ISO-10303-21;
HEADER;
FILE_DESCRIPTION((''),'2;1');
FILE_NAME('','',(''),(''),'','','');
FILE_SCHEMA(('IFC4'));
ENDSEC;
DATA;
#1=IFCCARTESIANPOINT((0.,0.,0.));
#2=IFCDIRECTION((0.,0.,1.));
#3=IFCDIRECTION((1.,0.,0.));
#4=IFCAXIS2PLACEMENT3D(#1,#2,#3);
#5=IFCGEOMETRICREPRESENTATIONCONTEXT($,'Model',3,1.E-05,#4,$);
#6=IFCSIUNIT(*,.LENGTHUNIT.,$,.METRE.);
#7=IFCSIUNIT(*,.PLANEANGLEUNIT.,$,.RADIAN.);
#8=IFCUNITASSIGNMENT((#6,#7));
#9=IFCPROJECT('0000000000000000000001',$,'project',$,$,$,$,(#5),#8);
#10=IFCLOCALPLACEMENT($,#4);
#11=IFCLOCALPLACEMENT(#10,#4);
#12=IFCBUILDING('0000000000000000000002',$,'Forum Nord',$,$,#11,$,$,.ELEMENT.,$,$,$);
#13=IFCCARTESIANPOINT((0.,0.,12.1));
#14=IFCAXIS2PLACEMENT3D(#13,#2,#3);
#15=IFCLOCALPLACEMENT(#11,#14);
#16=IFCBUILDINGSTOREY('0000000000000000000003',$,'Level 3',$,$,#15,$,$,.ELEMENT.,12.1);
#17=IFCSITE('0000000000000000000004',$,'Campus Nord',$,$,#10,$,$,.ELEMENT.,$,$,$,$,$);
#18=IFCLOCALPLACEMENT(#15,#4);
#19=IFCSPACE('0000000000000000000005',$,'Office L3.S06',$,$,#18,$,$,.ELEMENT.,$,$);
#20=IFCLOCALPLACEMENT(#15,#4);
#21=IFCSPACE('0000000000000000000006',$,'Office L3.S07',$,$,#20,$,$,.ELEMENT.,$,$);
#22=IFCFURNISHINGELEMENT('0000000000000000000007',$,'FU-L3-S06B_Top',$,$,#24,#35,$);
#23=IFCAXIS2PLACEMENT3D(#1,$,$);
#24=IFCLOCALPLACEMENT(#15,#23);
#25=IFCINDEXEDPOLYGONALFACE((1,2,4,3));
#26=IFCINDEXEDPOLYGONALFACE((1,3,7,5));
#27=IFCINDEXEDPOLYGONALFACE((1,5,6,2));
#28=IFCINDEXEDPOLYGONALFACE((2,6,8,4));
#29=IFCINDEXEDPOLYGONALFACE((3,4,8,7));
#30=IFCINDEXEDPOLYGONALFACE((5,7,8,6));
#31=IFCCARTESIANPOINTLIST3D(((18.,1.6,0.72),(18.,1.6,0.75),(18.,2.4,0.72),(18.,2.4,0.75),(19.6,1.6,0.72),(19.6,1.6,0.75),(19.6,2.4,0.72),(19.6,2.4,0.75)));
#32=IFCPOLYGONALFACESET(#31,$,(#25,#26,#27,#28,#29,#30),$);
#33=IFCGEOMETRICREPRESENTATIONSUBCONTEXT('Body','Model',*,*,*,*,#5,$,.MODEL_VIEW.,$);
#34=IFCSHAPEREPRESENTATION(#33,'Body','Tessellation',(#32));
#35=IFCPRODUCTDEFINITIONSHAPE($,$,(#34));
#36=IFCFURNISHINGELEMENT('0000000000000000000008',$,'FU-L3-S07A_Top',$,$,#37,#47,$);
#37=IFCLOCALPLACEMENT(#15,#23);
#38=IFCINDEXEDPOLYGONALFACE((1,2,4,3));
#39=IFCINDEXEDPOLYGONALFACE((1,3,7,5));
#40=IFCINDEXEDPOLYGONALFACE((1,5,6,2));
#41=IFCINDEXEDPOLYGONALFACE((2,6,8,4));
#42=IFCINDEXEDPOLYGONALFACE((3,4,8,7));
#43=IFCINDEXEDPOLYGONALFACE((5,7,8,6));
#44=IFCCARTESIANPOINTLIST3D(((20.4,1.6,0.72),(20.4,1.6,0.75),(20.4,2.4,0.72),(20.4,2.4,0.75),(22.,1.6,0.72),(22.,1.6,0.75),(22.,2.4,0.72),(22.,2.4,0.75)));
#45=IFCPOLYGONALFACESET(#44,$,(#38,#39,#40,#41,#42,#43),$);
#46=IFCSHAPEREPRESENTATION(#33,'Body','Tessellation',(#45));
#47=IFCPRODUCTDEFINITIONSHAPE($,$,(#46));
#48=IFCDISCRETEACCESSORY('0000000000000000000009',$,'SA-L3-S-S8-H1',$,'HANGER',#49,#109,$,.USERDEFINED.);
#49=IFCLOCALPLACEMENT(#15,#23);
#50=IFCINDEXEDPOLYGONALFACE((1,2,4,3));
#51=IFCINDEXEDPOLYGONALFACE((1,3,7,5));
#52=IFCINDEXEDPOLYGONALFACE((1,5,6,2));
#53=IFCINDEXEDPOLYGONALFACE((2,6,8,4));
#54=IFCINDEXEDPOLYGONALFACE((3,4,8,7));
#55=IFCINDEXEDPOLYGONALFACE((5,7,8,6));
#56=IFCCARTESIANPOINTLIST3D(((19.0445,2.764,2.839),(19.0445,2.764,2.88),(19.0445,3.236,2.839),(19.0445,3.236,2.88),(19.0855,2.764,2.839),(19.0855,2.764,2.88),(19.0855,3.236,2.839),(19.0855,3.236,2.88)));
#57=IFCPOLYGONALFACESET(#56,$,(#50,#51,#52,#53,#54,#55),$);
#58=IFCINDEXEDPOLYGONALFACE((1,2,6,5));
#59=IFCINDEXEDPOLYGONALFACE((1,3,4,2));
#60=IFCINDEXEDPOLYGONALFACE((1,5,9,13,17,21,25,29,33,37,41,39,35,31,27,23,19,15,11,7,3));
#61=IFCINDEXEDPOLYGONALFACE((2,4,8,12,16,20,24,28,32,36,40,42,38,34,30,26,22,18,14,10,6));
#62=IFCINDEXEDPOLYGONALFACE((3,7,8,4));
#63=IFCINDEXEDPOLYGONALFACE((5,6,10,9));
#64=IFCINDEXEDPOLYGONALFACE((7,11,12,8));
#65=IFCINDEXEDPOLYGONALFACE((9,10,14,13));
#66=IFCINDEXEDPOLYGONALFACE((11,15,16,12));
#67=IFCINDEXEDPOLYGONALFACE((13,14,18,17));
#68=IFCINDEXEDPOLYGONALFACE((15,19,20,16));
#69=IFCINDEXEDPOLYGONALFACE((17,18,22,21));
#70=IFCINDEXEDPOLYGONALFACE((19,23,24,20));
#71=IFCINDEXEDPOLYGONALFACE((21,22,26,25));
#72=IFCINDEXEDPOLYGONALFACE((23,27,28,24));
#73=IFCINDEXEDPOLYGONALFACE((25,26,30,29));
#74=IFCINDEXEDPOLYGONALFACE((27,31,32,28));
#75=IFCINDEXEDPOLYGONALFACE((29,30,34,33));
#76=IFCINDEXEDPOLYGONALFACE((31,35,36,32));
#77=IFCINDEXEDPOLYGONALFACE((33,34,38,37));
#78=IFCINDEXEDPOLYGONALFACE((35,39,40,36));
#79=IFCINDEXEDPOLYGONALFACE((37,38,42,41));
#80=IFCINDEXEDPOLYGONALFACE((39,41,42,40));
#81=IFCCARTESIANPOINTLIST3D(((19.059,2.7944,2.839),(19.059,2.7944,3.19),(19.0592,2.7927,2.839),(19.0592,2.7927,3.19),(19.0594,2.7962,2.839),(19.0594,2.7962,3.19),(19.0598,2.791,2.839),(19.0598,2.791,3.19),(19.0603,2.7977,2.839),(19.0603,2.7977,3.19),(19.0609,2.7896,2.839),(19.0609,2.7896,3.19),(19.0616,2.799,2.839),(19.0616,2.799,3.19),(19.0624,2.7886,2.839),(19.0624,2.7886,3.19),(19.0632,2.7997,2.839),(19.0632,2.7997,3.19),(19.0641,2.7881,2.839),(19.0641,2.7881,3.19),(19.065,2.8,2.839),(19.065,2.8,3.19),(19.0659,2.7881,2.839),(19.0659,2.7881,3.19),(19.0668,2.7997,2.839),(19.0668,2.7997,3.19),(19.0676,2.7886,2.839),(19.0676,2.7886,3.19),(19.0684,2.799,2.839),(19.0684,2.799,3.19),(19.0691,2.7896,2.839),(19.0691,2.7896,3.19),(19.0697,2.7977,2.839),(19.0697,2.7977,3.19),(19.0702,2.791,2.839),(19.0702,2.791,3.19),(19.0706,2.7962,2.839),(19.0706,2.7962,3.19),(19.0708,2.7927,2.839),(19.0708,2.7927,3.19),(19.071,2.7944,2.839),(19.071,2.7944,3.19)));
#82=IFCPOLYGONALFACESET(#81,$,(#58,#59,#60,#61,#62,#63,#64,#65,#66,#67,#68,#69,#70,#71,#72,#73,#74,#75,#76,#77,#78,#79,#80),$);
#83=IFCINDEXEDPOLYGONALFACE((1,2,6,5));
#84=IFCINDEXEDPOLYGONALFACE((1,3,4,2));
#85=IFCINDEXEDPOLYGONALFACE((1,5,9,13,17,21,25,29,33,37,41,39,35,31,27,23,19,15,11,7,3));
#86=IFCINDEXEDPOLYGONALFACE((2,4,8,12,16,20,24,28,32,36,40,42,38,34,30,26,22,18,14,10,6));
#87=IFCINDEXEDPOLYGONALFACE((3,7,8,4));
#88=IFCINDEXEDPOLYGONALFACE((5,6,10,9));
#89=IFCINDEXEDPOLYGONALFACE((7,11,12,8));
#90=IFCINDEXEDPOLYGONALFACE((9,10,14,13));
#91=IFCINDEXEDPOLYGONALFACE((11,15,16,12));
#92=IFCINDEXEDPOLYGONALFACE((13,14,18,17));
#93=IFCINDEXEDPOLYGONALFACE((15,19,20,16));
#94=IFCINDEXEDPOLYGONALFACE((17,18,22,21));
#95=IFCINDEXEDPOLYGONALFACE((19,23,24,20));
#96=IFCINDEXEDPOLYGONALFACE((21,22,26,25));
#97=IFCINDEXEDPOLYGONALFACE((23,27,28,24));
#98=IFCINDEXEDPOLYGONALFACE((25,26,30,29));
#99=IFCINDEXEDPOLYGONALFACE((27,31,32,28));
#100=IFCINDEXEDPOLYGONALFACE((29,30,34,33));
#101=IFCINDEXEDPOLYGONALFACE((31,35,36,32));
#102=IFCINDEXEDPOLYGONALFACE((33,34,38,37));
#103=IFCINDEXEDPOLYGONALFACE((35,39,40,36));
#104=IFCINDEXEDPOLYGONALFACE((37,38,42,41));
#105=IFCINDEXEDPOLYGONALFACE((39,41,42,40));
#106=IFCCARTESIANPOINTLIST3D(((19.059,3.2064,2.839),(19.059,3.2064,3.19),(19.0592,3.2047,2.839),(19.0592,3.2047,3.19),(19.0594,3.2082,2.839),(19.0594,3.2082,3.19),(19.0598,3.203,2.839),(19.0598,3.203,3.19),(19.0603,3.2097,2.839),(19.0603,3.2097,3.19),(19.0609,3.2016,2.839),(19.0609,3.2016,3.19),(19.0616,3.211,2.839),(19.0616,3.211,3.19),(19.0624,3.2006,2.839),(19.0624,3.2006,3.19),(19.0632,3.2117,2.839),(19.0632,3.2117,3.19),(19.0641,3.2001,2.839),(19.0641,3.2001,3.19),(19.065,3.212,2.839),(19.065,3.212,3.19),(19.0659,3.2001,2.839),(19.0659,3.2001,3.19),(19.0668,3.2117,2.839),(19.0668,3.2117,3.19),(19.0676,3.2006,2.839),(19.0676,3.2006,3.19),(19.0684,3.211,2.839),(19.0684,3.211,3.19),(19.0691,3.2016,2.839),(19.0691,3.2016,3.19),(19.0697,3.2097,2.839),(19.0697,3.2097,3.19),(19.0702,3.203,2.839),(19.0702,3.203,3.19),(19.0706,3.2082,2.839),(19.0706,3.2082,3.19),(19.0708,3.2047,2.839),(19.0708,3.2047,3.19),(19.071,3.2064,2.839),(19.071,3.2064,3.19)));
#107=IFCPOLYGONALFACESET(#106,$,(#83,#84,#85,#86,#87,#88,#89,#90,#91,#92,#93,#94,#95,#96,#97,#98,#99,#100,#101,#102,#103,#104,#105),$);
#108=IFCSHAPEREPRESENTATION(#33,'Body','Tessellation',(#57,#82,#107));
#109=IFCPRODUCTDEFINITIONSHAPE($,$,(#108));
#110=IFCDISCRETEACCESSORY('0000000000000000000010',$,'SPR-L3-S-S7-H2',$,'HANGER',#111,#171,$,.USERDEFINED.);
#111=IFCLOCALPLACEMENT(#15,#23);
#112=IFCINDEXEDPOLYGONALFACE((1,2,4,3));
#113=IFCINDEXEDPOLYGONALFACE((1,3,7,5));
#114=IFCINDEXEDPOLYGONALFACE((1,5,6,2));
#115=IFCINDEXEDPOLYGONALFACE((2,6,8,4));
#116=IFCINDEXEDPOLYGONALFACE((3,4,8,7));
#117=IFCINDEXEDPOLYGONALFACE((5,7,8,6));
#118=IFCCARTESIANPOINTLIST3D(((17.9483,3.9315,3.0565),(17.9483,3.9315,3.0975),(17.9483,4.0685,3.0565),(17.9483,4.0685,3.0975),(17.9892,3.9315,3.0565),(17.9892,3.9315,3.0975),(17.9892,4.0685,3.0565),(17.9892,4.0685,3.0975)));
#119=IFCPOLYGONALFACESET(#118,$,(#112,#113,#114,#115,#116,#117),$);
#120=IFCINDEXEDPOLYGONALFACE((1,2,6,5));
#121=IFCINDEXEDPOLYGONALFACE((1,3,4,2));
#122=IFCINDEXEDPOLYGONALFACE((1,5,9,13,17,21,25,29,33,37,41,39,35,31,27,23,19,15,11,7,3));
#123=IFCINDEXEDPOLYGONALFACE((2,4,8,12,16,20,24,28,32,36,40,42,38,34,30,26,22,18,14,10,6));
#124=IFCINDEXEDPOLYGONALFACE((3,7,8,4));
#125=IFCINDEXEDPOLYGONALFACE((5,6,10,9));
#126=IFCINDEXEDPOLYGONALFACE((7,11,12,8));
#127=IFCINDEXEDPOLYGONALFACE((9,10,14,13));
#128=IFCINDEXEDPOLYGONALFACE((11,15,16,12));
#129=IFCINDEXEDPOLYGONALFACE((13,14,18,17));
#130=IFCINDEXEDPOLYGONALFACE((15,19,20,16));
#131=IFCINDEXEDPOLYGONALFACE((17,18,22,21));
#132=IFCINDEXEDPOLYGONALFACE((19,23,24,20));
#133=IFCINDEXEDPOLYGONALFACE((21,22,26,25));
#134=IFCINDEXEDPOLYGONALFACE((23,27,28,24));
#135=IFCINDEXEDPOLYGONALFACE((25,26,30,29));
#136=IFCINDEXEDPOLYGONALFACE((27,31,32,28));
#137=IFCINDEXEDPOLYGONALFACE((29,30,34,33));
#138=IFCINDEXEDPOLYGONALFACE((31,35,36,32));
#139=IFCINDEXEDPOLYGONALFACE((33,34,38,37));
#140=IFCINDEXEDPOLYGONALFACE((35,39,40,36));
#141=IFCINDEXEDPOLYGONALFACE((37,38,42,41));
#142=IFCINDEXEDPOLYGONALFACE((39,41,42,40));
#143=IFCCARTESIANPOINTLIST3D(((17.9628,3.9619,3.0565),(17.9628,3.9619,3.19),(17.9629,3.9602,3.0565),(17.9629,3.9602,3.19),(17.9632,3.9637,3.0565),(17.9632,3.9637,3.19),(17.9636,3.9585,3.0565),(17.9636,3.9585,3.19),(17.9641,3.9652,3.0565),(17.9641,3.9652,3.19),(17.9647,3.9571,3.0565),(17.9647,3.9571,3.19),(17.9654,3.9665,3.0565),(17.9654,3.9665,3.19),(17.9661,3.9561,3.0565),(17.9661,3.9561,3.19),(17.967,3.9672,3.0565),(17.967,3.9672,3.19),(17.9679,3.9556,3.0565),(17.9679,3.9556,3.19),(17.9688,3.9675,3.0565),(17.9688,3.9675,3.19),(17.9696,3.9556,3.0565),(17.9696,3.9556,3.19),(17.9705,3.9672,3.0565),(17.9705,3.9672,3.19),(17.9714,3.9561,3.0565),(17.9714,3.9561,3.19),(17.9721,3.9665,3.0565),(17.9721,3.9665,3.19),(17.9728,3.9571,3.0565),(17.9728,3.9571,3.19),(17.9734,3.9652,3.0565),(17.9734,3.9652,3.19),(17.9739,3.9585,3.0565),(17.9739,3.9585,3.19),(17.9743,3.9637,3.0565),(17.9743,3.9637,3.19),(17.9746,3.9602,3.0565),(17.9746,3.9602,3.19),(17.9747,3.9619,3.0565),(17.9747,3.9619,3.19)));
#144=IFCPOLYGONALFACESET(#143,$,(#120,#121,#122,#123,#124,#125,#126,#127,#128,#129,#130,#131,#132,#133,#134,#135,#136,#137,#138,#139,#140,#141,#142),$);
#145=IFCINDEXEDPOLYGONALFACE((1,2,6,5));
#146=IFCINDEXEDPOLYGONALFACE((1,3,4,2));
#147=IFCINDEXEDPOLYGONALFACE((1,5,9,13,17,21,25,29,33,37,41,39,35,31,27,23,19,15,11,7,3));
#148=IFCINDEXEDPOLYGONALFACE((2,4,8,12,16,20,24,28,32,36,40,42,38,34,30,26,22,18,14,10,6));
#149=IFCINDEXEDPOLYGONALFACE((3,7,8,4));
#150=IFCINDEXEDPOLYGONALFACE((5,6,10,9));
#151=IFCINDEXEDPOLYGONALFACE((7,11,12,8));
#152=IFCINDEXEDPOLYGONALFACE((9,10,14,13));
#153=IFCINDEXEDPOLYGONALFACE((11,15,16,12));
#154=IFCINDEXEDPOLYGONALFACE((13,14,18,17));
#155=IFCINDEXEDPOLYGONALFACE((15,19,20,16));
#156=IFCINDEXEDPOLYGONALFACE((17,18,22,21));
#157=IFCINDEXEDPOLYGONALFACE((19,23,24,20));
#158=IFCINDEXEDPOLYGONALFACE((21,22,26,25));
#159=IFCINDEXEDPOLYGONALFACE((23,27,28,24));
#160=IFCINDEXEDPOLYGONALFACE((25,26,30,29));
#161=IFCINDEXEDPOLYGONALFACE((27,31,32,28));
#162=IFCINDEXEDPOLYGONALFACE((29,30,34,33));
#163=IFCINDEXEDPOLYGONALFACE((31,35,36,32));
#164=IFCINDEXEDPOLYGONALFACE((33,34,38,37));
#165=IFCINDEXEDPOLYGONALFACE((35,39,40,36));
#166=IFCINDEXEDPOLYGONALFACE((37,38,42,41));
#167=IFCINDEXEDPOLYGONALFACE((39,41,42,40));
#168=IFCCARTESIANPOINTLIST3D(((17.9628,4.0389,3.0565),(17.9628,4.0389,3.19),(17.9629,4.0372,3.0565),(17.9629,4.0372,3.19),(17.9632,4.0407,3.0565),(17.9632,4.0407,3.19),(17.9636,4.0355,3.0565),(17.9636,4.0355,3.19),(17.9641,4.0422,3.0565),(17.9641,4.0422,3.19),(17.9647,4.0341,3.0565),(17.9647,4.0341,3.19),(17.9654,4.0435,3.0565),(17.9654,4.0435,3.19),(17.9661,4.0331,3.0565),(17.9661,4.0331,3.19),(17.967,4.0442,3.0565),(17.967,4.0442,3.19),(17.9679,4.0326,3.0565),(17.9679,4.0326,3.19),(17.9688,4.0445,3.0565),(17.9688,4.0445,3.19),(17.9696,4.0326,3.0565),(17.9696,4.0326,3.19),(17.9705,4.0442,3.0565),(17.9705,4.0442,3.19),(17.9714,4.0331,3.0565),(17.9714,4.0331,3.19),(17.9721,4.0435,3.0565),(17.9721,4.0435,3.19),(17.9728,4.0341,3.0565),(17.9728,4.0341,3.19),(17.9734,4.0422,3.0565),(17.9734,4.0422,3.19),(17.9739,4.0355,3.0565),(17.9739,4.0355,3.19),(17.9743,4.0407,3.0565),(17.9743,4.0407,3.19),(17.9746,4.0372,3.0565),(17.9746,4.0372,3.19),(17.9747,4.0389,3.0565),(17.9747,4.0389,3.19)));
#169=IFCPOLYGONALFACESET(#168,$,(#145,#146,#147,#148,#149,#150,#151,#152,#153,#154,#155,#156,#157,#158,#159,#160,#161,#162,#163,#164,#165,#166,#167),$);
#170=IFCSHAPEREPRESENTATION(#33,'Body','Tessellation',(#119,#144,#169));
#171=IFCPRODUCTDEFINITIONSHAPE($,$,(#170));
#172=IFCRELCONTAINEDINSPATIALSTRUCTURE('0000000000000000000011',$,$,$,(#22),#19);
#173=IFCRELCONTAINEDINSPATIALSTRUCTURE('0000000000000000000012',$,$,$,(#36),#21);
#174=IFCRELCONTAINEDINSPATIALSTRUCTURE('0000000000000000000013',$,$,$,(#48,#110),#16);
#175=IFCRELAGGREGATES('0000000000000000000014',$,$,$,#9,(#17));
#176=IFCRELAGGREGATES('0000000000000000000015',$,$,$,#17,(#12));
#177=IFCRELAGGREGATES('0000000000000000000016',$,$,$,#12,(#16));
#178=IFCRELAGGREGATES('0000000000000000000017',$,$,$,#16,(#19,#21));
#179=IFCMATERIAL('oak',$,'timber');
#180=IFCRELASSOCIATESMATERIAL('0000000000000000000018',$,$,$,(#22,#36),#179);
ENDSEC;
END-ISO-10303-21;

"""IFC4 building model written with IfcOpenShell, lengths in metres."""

from ifc_helpers import new_model, si_unit, frame, frame_2d, origin_with_axes, origin_2d_with_axis, place, context, subcontext, project, spatial, rectangle, circle, extrude, material, element, save


model = new_model("IFC4")

# Units and contexts
model_context = context("Model", 3, precision=1e-05, world=origin_with_axes())
body_context = subcontext(model_context, "Body", "Model", "MODEL_VIEW")
ifc_project = project(units=[si_unit("LENGTHUNIT", "METRE"), si_unit("PLANEANGLEUNIT", "RADIAN")], contexts=[model_context])

# Site, building, storey
site_placement = place(None, origin_with_axes())
site = spatial("IfcSite", under=ifc_project, at=site_placement, Name="Campus Nord", CompositionType="ELEMENT")
building_placement = place(site_placement, origin_with_axes())
building = spatial("IfcBuilding", under=site, at=building_placement, Name="Forum Nord", CompositionType="ELEMENT")
storey_placement = place(building_placement, frame((0.0, 0.0, 12.1), z_axis=(0.0, 0.0, 1.0), x_axis=(1.0, 0.0, 0.0)))
storey = spatial("IfcBuildingStorey", under=building, at=storey_placement, Name="Level 3", CompositionType="ELEMENT", Elevation=12.1)

# Shared definitions
space_1_placement = place(storey_placement, origin_with_axes())
space_1 = spatial("IfcSpace", under=storey, at=space_1_placement, Name="Office L3.S06", CompositionType="ELEMENT")

# Furnishing element
ifc_material_1 = material(Name="oak", Category="timber")
furnishing_1_placement = place(storey_placement, frame((18.0, 1.0, 0.0), z_axis=(0.0, 0.0, 1.0), x_axis=(1.0, 0.0, 0.0)))
element("IfcFurnishingElement", 1, at=furnishing_1_placement, inside=space_1, material=ifc_material_1, Name="FU-L3-S06B_Top", context=body_context, shape_type="SweptSolid", body=[
    extrude(rectangle(XDim=1.6, YDim=0.8, at=frame_2d((0.8, 1.0), x_axis=(1.0, 0.0))), frame((0.0, 0.0, 0.72), z_axis=(0.0, 0.0, 1.0), x_axis=(1.0, 0.0, 0.0)), (0.0, 0.0, 1.0), 0.03),
])

# Shared definitions
space_2_placement = place(storey_placement, origin_with_axes())
space_2 = spatial("IfcSpace", under=storey, at=space_2_placement, Name="Office L3.S07", CompositionType="ELEMENT")

# Furnishing element
furnishing_2_placement = place(storey_placement, frame((20.4, 1.0, 0.0), z_axis=(0.0, 0.0, 1.0), x_axis=(1.0, 0.0, 0.0)))
element("IfcFurnishingElement", 2, at=furnishing_2_placement, inside=space_2, material=ifc_material_1, Name="FU-L3-S07A_Top", context=body_context, shape_type="SweptSolid", body=[
    extrude(rectangle(XDim=1.6, YDim=0.8, at=frame_2d((0.8, 1.0), x_axis=(1.0, 0.0))), frame((0.0, 0.0, 0.72), z_axis=(0.0, 0.0, 1.0), x_axis=(1.0, 0.0, 0.0)), (0.0, 0.0, 1.0), 0.03),
])

# Discrete accessories
discrete_accessory_1_placement = place(storey_placement, frame((19.065, 3.0, 2.88), z_axis=(0.0, 0.0, 1.0), x_axis=(0.0, 1.0, 0.0)))
element("IfcDiscreteAccessory", 3, at=discrete_accessory_1_placement, inside=storey, Name="SA-L3-S-S8-H1", ObjectType="HANGER", PredefinedType="USERDEFINED", context=body_context, shape_type="SweptSolid", body=[
    extrude(rectangle(XDim=0.472, YDim=0.041, at=origin_2d_with_axis()), frame((0.0, 0.0, -0.041), z_axis=(0.0, 0.0, 1.0), x_axis=(1.0, 0.0, 0.0)), (0.0, 0.0, 1.0), 0.041),
    extrude(circle(Radius=0.006, at=frame_2d((-0.206, 0.0), x_axis=(1.0, 0.0))), frame((0.0, 0.0, -0.041), z_axis=(0.0, 0.0, 1.0), x_axis=(1.0, 0.0, 0.0)), (0.0, 0.0, 1.0), 0.351),
    extrude(circle(Radius=0.006, at=frame_2d((0.206, 0.0), x_axis=(1.0, 0.0))), frame((0.0, 0.0, -0.041), z_axis=(0.0, 0.0, 1.0), x_axis=(1.0, 0.0, 0.0)), (0.0, 0.0, 1.0), 0.351),
])
discrete_accessory_2_placement = place(storey_placement, frame((17.9688, 4.0, 3.0975), z_axis=(0.0, 0.0, 1.0), x_axis=(0.0, 1.0, 0.0)))
element("IfcDiscreteAccessory", 4, at=discrete_accessory_2_placement, inside=storey, Name="SPR-L3-S-S7-H2", ObjectType="HANGER", PredefinedType="USERDEFINED", context=body_context, shape_type="SweptSolid", body=[
    extrude(rectangle(XDim=0.137, YDim=0.041, at=origin_2d_with_axis()), frame((0.0, 0.0, -0.041), z_axis=(0.0, 0.0, 1.0), x_axis=(1.0, 0.0, 0.0)), (0.0, 0.0, 1.0), 0.041),
    extrude(circle(Radius=0.006, at=frame_2d((-0.0385, 0.0), x_axis=(1.0, 0.0))), frame((0.0, 0.0, -0.041), z_axis=(0.0, 0.0, 1.0), x_axis=(1.0, 0.0, 0.0)), (0.0, 0.0, 1.0), 0.1335),
    extrude(circle(Radius=0.006, at=frame_2d((0.0385, 0.0), x_axis=(1.0, 0.0))), frame((0.0, 0.0, -0.041), z_axis=(0.0, 0.0, 1.0), x_axis=(1.0, 0.0, 0.0)), (0.0, 0.0, 1.0), 0.1335),
])

save(model, "model.ifc")
